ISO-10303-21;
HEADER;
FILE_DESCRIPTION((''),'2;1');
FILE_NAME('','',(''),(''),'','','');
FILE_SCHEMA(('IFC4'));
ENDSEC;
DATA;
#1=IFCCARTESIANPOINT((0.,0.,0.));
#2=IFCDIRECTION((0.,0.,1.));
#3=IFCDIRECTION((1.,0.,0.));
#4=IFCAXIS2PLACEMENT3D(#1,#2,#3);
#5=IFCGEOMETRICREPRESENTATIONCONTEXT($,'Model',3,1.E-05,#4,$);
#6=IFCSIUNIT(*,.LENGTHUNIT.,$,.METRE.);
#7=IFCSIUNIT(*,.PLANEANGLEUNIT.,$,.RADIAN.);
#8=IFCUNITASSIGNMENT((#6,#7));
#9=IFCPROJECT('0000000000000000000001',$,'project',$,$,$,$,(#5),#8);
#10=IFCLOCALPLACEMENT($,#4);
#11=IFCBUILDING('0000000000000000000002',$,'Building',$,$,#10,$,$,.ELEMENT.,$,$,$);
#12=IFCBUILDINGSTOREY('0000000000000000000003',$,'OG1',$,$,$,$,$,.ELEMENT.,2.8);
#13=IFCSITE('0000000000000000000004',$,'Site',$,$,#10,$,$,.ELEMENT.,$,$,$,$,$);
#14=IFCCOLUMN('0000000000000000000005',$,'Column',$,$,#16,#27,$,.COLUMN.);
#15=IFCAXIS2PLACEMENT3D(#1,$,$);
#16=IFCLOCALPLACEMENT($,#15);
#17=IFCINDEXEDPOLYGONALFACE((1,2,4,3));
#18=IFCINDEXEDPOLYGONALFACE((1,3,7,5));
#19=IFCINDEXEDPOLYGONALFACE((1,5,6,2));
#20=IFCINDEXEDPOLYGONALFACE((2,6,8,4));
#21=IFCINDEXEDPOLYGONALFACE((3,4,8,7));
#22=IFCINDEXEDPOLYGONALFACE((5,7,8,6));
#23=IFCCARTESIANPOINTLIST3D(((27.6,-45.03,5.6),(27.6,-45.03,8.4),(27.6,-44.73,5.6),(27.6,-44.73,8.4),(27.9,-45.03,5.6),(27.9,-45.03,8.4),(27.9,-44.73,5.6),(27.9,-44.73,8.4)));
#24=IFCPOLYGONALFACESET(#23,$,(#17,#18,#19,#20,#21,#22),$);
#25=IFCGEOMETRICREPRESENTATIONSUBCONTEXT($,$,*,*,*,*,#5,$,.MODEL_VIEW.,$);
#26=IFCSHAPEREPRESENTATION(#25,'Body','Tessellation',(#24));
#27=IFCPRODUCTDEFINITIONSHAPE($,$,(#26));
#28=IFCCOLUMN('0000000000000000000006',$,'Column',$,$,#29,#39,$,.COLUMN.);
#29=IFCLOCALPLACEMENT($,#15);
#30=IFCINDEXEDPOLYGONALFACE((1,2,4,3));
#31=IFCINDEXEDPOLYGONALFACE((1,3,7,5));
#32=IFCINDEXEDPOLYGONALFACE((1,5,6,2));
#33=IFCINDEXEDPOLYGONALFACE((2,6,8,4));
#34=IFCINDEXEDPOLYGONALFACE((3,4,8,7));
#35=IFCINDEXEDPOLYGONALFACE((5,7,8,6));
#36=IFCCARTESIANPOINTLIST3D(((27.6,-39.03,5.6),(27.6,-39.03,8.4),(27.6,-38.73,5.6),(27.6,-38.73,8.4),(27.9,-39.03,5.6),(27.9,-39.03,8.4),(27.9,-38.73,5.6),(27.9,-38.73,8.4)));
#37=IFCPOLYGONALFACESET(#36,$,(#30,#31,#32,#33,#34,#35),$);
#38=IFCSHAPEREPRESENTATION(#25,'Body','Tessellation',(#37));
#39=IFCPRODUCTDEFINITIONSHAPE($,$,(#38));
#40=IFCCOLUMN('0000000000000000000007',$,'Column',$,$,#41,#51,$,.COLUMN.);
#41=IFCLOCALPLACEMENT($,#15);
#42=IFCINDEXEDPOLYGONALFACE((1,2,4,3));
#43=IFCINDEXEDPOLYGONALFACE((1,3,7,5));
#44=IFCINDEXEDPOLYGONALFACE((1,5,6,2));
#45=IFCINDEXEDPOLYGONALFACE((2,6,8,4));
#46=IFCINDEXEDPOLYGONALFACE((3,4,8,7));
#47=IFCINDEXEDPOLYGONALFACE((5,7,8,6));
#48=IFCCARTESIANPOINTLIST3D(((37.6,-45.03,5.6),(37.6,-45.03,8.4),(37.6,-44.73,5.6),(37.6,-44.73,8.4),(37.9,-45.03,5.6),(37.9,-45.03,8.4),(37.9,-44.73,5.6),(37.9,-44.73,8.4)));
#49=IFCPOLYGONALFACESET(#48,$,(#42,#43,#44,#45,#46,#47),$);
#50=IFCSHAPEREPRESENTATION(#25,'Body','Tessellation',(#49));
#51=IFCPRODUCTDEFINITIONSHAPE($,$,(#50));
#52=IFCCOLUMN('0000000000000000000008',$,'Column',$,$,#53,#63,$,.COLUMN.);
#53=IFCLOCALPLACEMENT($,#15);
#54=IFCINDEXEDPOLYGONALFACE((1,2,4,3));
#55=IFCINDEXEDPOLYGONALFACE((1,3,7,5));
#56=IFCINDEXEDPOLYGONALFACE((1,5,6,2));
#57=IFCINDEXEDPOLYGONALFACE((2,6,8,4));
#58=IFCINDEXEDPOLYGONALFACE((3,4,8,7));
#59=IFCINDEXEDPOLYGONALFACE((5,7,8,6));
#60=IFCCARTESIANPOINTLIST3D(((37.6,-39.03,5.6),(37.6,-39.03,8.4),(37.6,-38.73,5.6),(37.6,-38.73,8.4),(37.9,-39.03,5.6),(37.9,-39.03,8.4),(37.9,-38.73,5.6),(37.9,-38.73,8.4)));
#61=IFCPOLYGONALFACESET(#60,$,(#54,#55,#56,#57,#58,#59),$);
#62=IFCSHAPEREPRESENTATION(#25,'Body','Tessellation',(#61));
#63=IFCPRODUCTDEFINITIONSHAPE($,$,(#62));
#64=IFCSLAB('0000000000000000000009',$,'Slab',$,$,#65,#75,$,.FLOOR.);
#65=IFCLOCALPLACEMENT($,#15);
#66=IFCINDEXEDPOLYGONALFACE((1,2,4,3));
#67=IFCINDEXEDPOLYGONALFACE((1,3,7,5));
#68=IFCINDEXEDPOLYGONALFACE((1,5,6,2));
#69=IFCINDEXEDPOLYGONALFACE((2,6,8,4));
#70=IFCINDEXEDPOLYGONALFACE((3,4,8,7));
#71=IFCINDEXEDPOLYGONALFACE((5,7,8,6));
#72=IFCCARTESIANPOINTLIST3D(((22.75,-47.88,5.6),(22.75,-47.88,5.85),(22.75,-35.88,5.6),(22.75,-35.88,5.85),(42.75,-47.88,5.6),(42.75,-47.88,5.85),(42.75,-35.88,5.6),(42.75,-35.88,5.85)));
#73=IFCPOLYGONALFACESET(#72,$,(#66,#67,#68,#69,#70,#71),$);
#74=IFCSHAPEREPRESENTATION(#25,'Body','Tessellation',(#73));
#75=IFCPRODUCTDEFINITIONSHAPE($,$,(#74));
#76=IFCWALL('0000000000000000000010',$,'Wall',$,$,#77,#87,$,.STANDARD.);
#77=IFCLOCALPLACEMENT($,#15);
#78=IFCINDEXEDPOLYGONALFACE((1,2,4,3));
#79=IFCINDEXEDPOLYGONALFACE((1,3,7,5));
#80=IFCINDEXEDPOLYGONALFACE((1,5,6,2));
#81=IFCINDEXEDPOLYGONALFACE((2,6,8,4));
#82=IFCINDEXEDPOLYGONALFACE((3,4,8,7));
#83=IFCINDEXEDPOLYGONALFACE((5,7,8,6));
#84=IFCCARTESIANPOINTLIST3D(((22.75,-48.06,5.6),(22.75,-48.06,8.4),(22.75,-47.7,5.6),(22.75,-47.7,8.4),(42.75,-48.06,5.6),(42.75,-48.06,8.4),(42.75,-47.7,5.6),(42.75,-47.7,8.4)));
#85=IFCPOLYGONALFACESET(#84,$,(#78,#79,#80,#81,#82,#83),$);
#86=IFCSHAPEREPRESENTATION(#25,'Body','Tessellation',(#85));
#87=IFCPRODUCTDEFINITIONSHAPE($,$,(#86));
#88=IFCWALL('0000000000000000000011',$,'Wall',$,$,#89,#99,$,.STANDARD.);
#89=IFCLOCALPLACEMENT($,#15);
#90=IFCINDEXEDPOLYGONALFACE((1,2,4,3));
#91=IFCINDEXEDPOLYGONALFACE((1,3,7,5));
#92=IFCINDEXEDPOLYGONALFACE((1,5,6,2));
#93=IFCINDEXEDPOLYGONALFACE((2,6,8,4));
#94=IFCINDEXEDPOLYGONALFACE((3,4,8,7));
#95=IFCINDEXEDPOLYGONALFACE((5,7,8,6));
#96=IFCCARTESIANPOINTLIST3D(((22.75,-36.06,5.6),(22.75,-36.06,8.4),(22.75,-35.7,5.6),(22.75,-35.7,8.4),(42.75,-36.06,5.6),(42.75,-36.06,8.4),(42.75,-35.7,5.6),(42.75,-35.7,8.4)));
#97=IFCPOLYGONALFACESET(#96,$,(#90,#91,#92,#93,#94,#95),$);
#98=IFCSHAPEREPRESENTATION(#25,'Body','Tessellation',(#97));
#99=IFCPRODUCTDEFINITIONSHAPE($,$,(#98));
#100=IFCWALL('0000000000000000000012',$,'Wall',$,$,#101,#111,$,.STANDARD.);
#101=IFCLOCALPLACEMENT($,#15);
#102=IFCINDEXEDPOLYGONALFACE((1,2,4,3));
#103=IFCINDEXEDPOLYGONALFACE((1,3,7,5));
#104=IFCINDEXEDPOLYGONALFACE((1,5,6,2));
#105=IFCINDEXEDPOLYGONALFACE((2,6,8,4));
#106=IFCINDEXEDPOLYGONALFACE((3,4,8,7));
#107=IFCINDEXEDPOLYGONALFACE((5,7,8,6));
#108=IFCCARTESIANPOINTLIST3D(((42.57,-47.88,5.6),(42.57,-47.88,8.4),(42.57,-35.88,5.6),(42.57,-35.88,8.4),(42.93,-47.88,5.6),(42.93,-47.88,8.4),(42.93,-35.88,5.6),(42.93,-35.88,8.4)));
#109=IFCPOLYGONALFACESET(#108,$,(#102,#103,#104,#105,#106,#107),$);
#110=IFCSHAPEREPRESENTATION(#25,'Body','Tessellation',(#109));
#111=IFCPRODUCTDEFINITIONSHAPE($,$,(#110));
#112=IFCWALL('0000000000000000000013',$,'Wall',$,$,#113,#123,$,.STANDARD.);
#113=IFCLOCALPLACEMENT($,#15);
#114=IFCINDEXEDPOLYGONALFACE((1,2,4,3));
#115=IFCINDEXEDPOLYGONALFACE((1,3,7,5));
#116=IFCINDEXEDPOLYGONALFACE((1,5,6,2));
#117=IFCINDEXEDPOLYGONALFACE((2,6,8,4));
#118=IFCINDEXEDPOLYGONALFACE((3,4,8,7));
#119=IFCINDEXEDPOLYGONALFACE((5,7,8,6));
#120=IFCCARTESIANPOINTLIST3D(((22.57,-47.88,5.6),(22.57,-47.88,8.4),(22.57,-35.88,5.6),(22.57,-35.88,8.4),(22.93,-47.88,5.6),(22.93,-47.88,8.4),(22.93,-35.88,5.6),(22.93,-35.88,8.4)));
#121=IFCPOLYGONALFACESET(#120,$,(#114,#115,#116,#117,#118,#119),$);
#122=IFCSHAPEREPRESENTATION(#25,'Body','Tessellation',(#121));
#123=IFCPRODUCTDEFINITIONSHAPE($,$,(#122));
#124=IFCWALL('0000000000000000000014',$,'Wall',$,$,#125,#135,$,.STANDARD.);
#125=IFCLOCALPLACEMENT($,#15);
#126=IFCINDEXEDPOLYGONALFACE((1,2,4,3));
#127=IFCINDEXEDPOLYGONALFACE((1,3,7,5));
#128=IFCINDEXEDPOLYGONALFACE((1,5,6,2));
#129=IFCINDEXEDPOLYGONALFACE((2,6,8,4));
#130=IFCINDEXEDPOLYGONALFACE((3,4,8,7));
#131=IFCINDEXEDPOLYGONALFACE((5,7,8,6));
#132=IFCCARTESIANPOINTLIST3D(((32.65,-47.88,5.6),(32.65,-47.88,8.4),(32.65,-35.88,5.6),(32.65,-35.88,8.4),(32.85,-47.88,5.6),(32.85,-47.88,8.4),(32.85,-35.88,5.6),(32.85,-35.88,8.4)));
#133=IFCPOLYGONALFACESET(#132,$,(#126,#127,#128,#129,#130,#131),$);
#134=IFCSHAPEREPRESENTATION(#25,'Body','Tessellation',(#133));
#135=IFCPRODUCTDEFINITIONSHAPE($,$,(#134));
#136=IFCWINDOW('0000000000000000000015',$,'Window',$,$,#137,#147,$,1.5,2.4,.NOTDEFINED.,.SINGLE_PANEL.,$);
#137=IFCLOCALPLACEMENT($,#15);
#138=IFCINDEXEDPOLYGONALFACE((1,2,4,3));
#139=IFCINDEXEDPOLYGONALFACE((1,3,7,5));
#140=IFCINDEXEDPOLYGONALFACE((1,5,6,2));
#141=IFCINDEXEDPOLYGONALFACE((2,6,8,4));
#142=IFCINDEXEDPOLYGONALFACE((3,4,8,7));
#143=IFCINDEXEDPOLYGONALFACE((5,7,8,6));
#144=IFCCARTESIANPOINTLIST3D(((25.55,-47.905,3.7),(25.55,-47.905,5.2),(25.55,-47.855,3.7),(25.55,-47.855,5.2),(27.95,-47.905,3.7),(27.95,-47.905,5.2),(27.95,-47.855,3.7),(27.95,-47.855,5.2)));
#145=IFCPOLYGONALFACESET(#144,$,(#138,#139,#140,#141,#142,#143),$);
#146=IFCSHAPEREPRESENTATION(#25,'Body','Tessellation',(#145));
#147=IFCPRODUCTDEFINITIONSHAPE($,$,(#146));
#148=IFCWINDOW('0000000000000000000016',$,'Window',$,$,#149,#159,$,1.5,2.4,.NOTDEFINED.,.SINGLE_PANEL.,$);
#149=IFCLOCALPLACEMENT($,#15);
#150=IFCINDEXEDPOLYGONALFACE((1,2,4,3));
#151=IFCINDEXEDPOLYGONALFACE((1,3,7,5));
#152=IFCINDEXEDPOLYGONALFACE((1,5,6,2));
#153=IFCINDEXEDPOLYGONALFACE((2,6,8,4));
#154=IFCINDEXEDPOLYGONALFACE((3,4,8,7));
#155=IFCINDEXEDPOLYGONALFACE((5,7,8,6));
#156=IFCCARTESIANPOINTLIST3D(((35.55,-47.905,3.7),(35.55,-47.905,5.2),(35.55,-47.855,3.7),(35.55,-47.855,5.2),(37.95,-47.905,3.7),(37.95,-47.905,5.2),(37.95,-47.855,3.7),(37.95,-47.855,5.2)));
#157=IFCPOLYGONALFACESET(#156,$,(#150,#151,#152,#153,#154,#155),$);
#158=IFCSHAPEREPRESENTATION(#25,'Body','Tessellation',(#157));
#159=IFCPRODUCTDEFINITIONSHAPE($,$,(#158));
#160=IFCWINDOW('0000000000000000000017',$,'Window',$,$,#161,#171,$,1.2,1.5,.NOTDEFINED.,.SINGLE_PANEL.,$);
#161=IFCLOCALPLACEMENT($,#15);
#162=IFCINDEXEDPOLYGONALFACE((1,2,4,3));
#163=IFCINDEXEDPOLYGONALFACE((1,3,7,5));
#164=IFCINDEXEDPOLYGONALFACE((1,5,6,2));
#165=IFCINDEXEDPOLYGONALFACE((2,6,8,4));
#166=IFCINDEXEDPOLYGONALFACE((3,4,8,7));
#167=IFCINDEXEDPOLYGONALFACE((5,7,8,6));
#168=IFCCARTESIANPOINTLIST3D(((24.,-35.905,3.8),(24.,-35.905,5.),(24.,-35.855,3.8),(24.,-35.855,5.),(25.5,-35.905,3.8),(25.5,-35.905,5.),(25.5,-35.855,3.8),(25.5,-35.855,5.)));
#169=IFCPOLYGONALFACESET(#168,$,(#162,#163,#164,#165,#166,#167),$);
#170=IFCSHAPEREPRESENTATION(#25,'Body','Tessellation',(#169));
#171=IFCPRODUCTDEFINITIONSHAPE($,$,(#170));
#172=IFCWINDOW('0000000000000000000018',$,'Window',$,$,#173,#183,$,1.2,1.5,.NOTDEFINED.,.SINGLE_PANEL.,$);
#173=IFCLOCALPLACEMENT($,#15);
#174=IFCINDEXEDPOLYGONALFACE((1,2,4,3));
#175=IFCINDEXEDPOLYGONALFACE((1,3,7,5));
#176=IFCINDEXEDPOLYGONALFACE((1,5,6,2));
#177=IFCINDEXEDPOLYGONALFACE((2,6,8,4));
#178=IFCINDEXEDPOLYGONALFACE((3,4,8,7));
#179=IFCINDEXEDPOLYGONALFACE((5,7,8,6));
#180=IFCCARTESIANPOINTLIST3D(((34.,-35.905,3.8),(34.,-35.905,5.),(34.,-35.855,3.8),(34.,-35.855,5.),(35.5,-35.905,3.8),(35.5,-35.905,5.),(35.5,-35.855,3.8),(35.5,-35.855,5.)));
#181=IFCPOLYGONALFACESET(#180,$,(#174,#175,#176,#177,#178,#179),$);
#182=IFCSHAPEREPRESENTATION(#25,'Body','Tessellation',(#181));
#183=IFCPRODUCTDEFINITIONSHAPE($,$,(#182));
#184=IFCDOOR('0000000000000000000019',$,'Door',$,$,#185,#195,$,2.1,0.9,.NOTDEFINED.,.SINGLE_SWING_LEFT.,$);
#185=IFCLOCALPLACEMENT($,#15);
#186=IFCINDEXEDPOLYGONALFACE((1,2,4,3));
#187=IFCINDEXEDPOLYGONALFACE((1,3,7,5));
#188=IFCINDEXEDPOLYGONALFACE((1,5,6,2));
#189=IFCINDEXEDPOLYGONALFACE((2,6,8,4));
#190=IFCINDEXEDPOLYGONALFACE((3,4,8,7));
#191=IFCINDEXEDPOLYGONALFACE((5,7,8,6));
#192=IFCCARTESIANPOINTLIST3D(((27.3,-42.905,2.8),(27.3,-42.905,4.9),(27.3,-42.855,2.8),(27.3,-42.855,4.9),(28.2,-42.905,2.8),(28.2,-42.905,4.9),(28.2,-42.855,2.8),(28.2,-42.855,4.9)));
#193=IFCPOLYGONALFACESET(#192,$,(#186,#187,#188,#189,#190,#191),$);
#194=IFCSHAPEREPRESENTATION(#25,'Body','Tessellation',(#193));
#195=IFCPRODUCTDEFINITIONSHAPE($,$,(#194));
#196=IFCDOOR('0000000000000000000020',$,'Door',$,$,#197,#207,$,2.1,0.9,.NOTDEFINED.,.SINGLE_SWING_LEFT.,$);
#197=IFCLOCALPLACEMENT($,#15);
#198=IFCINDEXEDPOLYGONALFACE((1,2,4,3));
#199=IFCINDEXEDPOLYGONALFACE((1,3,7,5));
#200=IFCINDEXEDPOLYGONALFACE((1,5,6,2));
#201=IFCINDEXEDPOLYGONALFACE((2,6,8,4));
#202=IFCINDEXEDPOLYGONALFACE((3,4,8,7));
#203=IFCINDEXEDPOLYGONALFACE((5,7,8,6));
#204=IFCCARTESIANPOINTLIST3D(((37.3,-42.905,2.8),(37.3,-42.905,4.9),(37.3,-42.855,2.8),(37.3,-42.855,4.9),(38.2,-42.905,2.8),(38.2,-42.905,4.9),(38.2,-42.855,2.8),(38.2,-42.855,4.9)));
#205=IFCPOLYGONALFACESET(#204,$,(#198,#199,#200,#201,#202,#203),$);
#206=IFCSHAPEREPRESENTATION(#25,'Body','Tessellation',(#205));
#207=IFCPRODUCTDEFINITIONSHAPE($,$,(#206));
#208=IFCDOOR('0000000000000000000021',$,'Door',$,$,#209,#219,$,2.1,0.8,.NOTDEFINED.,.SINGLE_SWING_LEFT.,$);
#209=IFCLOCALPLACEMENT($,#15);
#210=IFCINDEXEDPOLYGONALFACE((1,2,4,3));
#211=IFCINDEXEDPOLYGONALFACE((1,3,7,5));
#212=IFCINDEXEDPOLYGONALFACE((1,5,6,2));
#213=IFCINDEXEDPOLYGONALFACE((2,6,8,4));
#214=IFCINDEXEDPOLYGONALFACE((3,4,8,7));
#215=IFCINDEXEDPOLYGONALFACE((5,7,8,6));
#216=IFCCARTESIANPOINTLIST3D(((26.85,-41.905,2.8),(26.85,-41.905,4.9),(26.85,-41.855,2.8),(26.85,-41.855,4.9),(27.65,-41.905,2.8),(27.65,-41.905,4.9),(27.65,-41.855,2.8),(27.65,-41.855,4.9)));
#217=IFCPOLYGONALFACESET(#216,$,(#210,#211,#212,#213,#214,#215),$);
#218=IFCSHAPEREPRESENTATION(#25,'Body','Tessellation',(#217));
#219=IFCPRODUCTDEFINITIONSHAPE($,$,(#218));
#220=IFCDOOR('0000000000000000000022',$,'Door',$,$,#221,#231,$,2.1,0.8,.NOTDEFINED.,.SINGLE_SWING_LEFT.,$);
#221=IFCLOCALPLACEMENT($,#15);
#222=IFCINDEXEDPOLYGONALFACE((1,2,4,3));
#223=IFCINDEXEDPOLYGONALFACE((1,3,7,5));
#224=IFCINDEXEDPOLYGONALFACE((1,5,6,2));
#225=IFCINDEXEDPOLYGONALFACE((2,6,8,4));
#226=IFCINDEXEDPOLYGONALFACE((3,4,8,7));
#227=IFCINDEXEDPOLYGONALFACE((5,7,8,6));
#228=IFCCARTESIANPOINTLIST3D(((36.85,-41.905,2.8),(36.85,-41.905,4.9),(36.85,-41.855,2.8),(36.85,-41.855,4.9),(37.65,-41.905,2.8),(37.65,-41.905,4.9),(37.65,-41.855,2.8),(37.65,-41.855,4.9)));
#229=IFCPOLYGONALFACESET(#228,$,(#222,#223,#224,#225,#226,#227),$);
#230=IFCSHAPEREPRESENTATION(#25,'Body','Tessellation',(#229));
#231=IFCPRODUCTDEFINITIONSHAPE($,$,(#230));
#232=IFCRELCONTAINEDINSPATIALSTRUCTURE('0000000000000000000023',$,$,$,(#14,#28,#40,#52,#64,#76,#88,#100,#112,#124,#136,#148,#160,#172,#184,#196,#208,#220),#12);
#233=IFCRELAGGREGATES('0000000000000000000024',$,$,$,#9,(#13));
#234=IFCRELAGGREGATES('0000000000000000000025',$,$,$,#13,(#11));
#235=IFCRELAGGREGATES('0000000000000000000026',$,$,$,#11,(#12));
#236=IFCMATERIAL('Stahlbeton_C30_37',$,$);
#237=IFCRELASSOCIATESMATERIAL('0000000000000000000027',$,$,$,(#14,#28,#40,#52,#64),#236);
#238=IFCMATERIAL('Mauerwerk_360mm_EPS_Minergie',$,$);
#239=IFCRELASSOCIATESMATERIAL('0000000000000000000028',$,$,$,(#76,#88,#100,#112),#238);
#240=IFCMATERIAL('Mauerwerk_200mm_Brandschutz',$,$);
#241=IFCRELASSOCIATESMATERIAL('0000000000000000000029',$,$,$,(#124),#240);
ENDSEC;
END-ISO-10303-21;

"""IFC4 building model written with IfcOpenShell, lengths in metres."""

from ifc_helpers import new_model, si_unit, frame, frame_2d, origin, origin_with_axes, origin_2d, place, context, subcontext, project, spatial, rectangle, extrude, material, element, save


model = new_model("IFC4")

# Units and contexts
model_context = context("Model", 3, precision=1e-05, world=origin_with_axes())
sub_context = subcontext(model_context, None, None, "MODEL_VIEW")
ifc_project = project(units=[si_unit("LENGTHUNIT", "METRE"), si_unit("PLANEANGLEUNIT", "RADIAN")], contexts=[model_context])

# Site, building, storey
placement_1 = place(None, origin_with_axes())
site = spatial("IfcSite", under=ifc_project, at=placement_1, Name="Site", CompositionType="ELEMENT")
building = spatial("IfcBuilding", under=site, at=placement_1, Name="Building", CompositionType="ELEMENT")
storey = spatial("IfcBuildingStorey", under=building, Name="OG1", CompositionType="ELEMENT", Elevation=2.8)

# Columns
ifc_material_1 = material(Name="Stahlbeton_C30_37")
placement_2 = place(placement_1, frame((0.0, 0.0, 2.8)))
for number, where, name in (
    (1, (27.75, -44.88, 2.8), "Column"),
    (2, (27.75, -38.88, 2.8), "Column"),
    (3, (37.75, -44.88, 2.8), "Column"),
    (4, (37.75, -38.88, 2.8), "Column"),
):
    element("IfcColumn", number, at=place(placement_2, frame(where)), inside=storey, material=ifc_material_1, Name=name, PredefinedType="COLUMN", context=sub_context, shape_type="SweptSolid", body=[
        extrude(rectangle(XDim=0.3, YDim=0.3, at=origin_2d()), origin(), (0.0, 0.0, 1.0), 2.8),
    ])

# Slab
slab_placement = place(placement_2, frame((22.75, -47.88, 2.8)))
element("IfcSlab", 5, at=slab_placement, inside=storey, material=ifc_material_1, Name="Slab", PredefinedType="FLOOR", context=sub_context, shape_type="SweptSolid", body=[
    extrude(rectangle(XDim=20.0, YDim=12.0, at=frame_2d((10.0, 6.0))), origin(), (0.0, 0.0, 1.0), 0.25),
])

# Walls
ifc_material_2 = material(Name="Mauerwerk_360mm_EPS_Minergie")
for number, where, x_axis, name in (
    (6, (22.75, -47.88, 2.8), (1.0, 0.0, 0.0), "Wall"),
    (7, (22.75, -35.88, 2.8), (1.0, 0.0, 0.0), "Wall"),
):
    element("IfcWall", number, at=place(placement_2, frame(where, x_axis=x_axis)), inside=storey, material=ifc_material_2, Name=name, PredefinedType="STANDARD", context=sub_context, shape_type="SweptSolid", body=[
        extrude(rectangle(XDim=20.0, YDim=0.36, at=frame_2d((10.0, 0.0))), origin(), (0.0, 0.0, 1.0), 2.8),
    ])
for number, where, x_axis, name in (
    (8, (42.75, -47.88, 2.8), (0.0, 1.0, 0.0), "Wall"),
    (9, (22.75, -47.88, 2.8), (0.0, 1.0, 0.0), "Wall"),
):
    element("IfcWall", number, at=place(placement_2, frame(where, x_axis=x_axis)), inside=storey, material=ifc_material_2, Name=name, PredefinedType="STANDARD", context=sub_context, shape_type="SweptSolid", body=[
        extrude(rectangle(XDim=12.0, YDim=0.36, at=frame_2d((6.0, 0.0))), origin(), (0.0, 0.0, 1.0), 2.8),
    ])
ifc_material_3 = material(Name="Mauerwerk_200mm_Brandschutz")
wall_placement = place(placement_2, frame((32.75, -47.88, 2.8), x_axis=(0.0, 1.0, 0.0)))
element("IfcWall", 10, at=wall_placement, inside=storey, material=ifc_material_3, Name="Wall", PredefinedType="STANDARD", context=sub_context, shape_type="SweptSolid", body=[
    extrude(rectangle(XDim=12.0, YDim=0.2, at=frame_2d((6.0, 0.0))), origin(), (0.0, 0.0, 1.0), 2.8),
])

# Windows
for number, where, name in (
    (11, (26.75, -47.88, 3.7), "Window"),
    (12, (36.75, -47.88, 3.7), "Window"),
):
    element("IfcWindow", number, at=place(placement_1, frame(where)), inside=storey, Name=name, OverallHeight=1.5, OverallWidth=2.4, PartitioningType="SINGLE_PANEL", PredefinedType="NOTDEFINED", context=sub_context, shape_type="SweptSolid", body=[
        extrude(rectangle(XDim=2.4, YDim=0.05, at=origin_2d()), origin(), (0.0, 0.0, 1.0), 1.5),
    ])
for number, where, name in (
    (13, (24.75, -35.88, 3.8), "Window"),
    (14, (34.75, -35.88, 3.8), "Window"),
):
    element("IfcWindow", number, at=place(placement_1, frame(where)), inside=storey, Name=name, OverallHeight=1.2, OverallWidth=1.5, PartitioningType="SINGLE_PANEL", PredefinedType="NOTDEFINED", context=sub_context, shape_type="SweptSolid", body=[
        extrude(rectangle(XDim=1.5, YDim=0.05, at=origin_2d()), origin(), (0.0, 0.0, 1.0), 1.2),
    ])

# Doors
for number, where, name in (
    (15, (27.75, -42.88, 2.8), "Door"),
    (16, (37.75, -42.88, 2.8), "Door"),
):
    element("IfcDoor", number, at=place(placement_1, frame(where)), inside=storey, Name=name, OperationType="SINGLE_SWING_LEFT", OverallHeight=2.1, OverallWidth=0.9, PredefinedType="NOTDEFINED", context=sub_context, shape_type="SweptSolid", body=[
        extrude(rectangle(XDim=0.9, YDim=0.05, at=origin_2d()), origin(), (0.0, 0.0, 1.0), 2.1),
    ])
for number, where, name in (
    (17, (27.25, -41.88, 2.8), "Door"),
    (18, (37.25, -41.88, 2.8), "Door"),
):
    element("IfcDoor", number, at=place(placement_1, frame(where)), inside=storey, Name=name, OperationType="SINGLE_SWING_LEFT", OverallHeight=2.1, OverallWidth=0.8, PredefinedType="NOTDEFINED", context=sub_context, shape_type="SweptSolid", body=[
        extrude(rectangle(XDim=0.8, YDim=0.05, at=origin_2d()), origin(), (0.0, 0.0, 1.0), 2.1),
    ])

save(model, "model.ifc")
